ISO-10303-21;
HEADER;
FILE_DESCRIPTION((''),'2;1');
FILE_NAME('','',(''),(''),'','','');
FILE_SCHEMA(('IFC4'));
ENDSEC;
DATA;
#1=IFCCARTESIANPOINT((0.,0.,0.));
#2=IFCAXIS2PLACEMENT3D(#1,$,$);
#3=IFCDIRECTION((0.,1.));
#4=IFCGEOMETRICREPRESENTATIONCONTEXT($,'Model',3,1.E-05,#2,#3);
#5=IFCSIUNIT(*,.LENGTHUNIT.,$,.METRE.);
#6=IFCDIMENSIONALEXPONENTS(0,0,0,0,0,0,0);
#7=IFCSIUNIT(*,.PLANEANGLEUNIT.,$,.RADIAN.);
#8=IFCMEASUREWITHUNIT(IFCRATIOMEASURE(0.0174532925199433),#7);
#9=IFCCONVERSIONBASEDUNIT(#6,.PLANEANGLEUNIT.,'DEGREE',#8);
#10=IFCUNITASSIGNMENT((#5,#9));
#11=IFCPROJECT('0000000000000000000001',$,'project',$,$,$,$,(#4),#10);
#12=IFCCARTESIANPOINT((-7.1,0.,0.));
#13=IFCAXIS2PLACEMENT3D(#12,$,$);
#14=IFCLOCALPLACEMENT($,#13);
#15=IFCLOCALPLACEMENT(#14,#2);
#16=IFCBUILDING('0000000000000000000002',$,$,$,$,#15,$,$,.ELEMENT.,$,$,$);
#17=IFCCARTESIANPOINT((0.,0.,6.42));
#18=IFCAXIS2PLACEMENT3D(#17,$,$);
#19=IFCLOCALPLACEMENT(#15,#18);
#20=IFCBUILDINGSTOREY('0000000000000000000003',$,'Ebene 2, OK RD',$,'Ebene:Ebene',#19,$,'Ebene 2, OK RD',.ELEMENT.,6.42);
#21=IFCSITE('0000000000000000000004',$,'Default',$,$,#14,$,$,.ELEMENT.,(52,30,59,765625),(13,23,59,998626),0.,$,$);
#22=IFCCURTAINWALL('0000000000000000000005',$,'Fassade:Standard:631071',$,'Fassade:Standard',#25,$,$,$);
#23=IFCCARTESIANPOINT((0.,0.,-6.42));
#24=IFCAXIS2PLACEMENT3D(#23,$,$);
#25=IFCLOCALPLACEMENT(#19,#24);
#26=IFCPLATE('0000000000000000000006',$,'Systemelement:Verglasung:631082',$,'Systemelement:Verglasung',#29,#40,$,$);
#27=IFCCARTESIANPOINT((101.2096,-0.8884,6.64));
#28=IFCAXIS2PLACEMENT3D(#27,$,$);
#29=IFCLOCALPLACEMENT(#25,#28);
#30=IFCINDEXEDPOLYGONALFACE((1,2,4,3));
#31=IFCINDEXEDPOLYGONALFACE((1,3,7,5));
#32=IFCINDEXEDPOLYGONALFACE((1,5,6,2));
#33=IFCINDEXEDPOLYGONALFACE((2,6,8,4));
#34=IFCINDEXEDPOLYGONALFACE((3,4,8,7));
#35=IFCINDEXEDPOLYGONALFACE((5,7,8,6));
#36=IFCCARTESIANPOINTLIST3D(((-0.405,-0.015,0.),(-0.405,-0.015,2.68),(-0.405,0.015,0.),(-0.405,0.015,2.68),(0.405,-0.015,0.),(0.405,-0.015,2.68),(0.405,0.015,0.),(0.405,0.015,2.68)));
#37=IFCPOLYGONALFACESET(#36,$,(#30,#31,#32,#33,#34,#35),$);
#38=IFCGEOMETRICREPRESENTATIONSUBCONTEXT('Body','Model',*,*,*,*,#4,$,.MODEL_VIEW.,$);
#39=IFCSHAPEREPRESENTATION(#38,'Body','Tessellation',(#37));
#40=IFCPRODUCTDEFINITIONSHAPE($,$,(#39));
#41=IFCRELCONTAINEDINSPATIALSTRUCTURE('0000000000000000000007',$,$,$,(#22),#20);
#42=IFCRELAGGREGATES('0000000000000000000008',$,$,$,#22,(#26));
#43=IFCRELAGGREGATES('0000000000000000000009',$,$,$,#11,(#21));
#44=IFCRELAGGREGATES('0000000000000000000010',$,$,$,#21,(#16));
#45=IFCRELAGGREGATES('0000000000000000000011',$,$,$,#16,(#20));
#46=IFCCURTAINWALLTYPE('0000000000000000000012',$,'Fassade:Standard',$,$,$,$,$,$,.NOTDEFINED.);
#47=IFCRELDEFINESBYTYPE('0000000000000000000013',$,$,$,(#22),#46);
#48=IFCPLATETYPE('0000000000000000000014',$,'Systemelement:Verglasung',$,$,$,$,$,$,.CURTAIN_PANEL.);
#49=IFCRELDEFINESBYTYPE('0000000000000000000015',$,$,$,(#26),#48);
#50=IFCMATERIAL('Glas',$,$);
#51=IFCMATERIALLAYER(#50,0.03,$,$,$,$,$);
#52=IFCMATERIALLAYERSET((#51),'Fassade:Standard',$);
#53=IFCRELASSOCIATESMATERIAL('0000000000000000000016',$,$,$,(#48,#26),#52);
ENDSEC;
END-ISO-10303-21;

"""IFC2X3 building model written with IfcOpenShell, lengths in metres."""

from ifc_helpers import new_model, entity, si_unit, converted_unit, direction, frame, origin, origin_2d_with_axis, place, context, subcontext, project, spatial, rectangle, extrude, source, transform, mapped, material, layer, layer_set, layer_usage, type_object, type_shapes, element, aggregate, save


model = new_model("IFC2X3")

# Units and contexts
model_context = context("Model", 3, precision=1e-05, world=origin(), true_north=direction((0.0, 1.0)))
body_context = subcontext(model_context, "Body", "Model", "MODEL_VIEW")
ifc_project = project(units=[si_unit("LENGTHUNIT", "METRE"), converted_unit("PLANEANGLEUNIT", "DEGREE", entity("IfcRatioMeasure", 0.0174532925199433), si_unit("PLANEANGLEUNIT", "RADIAN"), dimensions=[0, 0, 0, 0, 0, 0, 0])], contexts=[model_context])

# Site, building, storey
site_placement = place(None, frame((-7.1, 0.0, 0.0)))
site = spatial("IfcSite", under=ifc_project, at=site_placement, Name="Default", CompositionType="ELEMENT", RefLatitude=(52, 30, 59, 765625), RefLongitude=(13, 23, 59, 998626), RefElevation=0.0)
building_placement = place(site_placement, origin())
building = spatial("IfcBuilding", under=site, at=building_placement, CompositionType="ELEMENT")
storey_placement = place(building_placement, frame((0.0, 0.0, 6.42)))
storey = spatial("IfcBuildingStorey", under=building, at=storey_placement, Name="Ebene 2, OK RD", ObjectType="Ebene:Ebene", LongName="Ebene 2, OK RD", CompositionType="ELEMENT", Elevation=6.42)

# Curtain wall
curtain_wall_type = type_object("IfcCurtainWallType", Name="Fassade:Standard", PredefinedType="NOTDEFINED")
curtain_wall_placement = place(storey_placement, frame((0.0, 0.0, -6.42)))
curtain_wall = element("IfcCurtainWall", 1, at=curtain_wall_placement, inside=storey, type_object=curtain_wall_type, Name="Fassade:Standard:631071", ObjectType="Fassade:Standard")

# Plate
ifc_material_1 = material(Name="Glas")
ifc_layer_1 = layer(ifc_material_1, 0.03)
ifc_layer_set_1 = layer_set([ifc_layer_1], Name="Fassade:Standard")
ifc_layer_usage_1 = layer_usage(ifc_layer_set_1, "AXIS3", "POSITIVE", 0.0)
plate_type = type_object("IfcPlateType", Name="Systemelement:Verglasung", PredefinedType="CURTAIN_PANEL", material=ifc_layer_set_1)
shared_shape_1 = source(origin(), body_context, "Body", "SweptSolid", [
    extrude(rectangle(XDim=0.03, YDim=0.81, at=origin_2d_with_axis()), frame((0.0, 0.0, 0.0), z_axis=(0.0, 0.0, 1.0), x_axis=(0.0, 1.0, 0.0)), (0.0, 0.0, 1.0), 2.68),
])
type_shapes(plate_type, [shared_shape_1])
plate_placement = place(curtain_wall_placement, frame((101.2096, -0.8884, 6.64)))
plate = element("IfcPlate", 2, at=plate_placement, type_object=plate_type, material=ifc_layer_usage_1, Name="Systemelement:Verglasung:631082", ObjectType="Systemelement:Verglasung", context=body_context, shape_type="MappedRepresentation", body=[
    mapped(shared_shape_1, transform((0.0, 0.0, 0.0), scale=1.0)),
])
aggregate(curtain_wall, [plate])

save(model, "model.ifc")
